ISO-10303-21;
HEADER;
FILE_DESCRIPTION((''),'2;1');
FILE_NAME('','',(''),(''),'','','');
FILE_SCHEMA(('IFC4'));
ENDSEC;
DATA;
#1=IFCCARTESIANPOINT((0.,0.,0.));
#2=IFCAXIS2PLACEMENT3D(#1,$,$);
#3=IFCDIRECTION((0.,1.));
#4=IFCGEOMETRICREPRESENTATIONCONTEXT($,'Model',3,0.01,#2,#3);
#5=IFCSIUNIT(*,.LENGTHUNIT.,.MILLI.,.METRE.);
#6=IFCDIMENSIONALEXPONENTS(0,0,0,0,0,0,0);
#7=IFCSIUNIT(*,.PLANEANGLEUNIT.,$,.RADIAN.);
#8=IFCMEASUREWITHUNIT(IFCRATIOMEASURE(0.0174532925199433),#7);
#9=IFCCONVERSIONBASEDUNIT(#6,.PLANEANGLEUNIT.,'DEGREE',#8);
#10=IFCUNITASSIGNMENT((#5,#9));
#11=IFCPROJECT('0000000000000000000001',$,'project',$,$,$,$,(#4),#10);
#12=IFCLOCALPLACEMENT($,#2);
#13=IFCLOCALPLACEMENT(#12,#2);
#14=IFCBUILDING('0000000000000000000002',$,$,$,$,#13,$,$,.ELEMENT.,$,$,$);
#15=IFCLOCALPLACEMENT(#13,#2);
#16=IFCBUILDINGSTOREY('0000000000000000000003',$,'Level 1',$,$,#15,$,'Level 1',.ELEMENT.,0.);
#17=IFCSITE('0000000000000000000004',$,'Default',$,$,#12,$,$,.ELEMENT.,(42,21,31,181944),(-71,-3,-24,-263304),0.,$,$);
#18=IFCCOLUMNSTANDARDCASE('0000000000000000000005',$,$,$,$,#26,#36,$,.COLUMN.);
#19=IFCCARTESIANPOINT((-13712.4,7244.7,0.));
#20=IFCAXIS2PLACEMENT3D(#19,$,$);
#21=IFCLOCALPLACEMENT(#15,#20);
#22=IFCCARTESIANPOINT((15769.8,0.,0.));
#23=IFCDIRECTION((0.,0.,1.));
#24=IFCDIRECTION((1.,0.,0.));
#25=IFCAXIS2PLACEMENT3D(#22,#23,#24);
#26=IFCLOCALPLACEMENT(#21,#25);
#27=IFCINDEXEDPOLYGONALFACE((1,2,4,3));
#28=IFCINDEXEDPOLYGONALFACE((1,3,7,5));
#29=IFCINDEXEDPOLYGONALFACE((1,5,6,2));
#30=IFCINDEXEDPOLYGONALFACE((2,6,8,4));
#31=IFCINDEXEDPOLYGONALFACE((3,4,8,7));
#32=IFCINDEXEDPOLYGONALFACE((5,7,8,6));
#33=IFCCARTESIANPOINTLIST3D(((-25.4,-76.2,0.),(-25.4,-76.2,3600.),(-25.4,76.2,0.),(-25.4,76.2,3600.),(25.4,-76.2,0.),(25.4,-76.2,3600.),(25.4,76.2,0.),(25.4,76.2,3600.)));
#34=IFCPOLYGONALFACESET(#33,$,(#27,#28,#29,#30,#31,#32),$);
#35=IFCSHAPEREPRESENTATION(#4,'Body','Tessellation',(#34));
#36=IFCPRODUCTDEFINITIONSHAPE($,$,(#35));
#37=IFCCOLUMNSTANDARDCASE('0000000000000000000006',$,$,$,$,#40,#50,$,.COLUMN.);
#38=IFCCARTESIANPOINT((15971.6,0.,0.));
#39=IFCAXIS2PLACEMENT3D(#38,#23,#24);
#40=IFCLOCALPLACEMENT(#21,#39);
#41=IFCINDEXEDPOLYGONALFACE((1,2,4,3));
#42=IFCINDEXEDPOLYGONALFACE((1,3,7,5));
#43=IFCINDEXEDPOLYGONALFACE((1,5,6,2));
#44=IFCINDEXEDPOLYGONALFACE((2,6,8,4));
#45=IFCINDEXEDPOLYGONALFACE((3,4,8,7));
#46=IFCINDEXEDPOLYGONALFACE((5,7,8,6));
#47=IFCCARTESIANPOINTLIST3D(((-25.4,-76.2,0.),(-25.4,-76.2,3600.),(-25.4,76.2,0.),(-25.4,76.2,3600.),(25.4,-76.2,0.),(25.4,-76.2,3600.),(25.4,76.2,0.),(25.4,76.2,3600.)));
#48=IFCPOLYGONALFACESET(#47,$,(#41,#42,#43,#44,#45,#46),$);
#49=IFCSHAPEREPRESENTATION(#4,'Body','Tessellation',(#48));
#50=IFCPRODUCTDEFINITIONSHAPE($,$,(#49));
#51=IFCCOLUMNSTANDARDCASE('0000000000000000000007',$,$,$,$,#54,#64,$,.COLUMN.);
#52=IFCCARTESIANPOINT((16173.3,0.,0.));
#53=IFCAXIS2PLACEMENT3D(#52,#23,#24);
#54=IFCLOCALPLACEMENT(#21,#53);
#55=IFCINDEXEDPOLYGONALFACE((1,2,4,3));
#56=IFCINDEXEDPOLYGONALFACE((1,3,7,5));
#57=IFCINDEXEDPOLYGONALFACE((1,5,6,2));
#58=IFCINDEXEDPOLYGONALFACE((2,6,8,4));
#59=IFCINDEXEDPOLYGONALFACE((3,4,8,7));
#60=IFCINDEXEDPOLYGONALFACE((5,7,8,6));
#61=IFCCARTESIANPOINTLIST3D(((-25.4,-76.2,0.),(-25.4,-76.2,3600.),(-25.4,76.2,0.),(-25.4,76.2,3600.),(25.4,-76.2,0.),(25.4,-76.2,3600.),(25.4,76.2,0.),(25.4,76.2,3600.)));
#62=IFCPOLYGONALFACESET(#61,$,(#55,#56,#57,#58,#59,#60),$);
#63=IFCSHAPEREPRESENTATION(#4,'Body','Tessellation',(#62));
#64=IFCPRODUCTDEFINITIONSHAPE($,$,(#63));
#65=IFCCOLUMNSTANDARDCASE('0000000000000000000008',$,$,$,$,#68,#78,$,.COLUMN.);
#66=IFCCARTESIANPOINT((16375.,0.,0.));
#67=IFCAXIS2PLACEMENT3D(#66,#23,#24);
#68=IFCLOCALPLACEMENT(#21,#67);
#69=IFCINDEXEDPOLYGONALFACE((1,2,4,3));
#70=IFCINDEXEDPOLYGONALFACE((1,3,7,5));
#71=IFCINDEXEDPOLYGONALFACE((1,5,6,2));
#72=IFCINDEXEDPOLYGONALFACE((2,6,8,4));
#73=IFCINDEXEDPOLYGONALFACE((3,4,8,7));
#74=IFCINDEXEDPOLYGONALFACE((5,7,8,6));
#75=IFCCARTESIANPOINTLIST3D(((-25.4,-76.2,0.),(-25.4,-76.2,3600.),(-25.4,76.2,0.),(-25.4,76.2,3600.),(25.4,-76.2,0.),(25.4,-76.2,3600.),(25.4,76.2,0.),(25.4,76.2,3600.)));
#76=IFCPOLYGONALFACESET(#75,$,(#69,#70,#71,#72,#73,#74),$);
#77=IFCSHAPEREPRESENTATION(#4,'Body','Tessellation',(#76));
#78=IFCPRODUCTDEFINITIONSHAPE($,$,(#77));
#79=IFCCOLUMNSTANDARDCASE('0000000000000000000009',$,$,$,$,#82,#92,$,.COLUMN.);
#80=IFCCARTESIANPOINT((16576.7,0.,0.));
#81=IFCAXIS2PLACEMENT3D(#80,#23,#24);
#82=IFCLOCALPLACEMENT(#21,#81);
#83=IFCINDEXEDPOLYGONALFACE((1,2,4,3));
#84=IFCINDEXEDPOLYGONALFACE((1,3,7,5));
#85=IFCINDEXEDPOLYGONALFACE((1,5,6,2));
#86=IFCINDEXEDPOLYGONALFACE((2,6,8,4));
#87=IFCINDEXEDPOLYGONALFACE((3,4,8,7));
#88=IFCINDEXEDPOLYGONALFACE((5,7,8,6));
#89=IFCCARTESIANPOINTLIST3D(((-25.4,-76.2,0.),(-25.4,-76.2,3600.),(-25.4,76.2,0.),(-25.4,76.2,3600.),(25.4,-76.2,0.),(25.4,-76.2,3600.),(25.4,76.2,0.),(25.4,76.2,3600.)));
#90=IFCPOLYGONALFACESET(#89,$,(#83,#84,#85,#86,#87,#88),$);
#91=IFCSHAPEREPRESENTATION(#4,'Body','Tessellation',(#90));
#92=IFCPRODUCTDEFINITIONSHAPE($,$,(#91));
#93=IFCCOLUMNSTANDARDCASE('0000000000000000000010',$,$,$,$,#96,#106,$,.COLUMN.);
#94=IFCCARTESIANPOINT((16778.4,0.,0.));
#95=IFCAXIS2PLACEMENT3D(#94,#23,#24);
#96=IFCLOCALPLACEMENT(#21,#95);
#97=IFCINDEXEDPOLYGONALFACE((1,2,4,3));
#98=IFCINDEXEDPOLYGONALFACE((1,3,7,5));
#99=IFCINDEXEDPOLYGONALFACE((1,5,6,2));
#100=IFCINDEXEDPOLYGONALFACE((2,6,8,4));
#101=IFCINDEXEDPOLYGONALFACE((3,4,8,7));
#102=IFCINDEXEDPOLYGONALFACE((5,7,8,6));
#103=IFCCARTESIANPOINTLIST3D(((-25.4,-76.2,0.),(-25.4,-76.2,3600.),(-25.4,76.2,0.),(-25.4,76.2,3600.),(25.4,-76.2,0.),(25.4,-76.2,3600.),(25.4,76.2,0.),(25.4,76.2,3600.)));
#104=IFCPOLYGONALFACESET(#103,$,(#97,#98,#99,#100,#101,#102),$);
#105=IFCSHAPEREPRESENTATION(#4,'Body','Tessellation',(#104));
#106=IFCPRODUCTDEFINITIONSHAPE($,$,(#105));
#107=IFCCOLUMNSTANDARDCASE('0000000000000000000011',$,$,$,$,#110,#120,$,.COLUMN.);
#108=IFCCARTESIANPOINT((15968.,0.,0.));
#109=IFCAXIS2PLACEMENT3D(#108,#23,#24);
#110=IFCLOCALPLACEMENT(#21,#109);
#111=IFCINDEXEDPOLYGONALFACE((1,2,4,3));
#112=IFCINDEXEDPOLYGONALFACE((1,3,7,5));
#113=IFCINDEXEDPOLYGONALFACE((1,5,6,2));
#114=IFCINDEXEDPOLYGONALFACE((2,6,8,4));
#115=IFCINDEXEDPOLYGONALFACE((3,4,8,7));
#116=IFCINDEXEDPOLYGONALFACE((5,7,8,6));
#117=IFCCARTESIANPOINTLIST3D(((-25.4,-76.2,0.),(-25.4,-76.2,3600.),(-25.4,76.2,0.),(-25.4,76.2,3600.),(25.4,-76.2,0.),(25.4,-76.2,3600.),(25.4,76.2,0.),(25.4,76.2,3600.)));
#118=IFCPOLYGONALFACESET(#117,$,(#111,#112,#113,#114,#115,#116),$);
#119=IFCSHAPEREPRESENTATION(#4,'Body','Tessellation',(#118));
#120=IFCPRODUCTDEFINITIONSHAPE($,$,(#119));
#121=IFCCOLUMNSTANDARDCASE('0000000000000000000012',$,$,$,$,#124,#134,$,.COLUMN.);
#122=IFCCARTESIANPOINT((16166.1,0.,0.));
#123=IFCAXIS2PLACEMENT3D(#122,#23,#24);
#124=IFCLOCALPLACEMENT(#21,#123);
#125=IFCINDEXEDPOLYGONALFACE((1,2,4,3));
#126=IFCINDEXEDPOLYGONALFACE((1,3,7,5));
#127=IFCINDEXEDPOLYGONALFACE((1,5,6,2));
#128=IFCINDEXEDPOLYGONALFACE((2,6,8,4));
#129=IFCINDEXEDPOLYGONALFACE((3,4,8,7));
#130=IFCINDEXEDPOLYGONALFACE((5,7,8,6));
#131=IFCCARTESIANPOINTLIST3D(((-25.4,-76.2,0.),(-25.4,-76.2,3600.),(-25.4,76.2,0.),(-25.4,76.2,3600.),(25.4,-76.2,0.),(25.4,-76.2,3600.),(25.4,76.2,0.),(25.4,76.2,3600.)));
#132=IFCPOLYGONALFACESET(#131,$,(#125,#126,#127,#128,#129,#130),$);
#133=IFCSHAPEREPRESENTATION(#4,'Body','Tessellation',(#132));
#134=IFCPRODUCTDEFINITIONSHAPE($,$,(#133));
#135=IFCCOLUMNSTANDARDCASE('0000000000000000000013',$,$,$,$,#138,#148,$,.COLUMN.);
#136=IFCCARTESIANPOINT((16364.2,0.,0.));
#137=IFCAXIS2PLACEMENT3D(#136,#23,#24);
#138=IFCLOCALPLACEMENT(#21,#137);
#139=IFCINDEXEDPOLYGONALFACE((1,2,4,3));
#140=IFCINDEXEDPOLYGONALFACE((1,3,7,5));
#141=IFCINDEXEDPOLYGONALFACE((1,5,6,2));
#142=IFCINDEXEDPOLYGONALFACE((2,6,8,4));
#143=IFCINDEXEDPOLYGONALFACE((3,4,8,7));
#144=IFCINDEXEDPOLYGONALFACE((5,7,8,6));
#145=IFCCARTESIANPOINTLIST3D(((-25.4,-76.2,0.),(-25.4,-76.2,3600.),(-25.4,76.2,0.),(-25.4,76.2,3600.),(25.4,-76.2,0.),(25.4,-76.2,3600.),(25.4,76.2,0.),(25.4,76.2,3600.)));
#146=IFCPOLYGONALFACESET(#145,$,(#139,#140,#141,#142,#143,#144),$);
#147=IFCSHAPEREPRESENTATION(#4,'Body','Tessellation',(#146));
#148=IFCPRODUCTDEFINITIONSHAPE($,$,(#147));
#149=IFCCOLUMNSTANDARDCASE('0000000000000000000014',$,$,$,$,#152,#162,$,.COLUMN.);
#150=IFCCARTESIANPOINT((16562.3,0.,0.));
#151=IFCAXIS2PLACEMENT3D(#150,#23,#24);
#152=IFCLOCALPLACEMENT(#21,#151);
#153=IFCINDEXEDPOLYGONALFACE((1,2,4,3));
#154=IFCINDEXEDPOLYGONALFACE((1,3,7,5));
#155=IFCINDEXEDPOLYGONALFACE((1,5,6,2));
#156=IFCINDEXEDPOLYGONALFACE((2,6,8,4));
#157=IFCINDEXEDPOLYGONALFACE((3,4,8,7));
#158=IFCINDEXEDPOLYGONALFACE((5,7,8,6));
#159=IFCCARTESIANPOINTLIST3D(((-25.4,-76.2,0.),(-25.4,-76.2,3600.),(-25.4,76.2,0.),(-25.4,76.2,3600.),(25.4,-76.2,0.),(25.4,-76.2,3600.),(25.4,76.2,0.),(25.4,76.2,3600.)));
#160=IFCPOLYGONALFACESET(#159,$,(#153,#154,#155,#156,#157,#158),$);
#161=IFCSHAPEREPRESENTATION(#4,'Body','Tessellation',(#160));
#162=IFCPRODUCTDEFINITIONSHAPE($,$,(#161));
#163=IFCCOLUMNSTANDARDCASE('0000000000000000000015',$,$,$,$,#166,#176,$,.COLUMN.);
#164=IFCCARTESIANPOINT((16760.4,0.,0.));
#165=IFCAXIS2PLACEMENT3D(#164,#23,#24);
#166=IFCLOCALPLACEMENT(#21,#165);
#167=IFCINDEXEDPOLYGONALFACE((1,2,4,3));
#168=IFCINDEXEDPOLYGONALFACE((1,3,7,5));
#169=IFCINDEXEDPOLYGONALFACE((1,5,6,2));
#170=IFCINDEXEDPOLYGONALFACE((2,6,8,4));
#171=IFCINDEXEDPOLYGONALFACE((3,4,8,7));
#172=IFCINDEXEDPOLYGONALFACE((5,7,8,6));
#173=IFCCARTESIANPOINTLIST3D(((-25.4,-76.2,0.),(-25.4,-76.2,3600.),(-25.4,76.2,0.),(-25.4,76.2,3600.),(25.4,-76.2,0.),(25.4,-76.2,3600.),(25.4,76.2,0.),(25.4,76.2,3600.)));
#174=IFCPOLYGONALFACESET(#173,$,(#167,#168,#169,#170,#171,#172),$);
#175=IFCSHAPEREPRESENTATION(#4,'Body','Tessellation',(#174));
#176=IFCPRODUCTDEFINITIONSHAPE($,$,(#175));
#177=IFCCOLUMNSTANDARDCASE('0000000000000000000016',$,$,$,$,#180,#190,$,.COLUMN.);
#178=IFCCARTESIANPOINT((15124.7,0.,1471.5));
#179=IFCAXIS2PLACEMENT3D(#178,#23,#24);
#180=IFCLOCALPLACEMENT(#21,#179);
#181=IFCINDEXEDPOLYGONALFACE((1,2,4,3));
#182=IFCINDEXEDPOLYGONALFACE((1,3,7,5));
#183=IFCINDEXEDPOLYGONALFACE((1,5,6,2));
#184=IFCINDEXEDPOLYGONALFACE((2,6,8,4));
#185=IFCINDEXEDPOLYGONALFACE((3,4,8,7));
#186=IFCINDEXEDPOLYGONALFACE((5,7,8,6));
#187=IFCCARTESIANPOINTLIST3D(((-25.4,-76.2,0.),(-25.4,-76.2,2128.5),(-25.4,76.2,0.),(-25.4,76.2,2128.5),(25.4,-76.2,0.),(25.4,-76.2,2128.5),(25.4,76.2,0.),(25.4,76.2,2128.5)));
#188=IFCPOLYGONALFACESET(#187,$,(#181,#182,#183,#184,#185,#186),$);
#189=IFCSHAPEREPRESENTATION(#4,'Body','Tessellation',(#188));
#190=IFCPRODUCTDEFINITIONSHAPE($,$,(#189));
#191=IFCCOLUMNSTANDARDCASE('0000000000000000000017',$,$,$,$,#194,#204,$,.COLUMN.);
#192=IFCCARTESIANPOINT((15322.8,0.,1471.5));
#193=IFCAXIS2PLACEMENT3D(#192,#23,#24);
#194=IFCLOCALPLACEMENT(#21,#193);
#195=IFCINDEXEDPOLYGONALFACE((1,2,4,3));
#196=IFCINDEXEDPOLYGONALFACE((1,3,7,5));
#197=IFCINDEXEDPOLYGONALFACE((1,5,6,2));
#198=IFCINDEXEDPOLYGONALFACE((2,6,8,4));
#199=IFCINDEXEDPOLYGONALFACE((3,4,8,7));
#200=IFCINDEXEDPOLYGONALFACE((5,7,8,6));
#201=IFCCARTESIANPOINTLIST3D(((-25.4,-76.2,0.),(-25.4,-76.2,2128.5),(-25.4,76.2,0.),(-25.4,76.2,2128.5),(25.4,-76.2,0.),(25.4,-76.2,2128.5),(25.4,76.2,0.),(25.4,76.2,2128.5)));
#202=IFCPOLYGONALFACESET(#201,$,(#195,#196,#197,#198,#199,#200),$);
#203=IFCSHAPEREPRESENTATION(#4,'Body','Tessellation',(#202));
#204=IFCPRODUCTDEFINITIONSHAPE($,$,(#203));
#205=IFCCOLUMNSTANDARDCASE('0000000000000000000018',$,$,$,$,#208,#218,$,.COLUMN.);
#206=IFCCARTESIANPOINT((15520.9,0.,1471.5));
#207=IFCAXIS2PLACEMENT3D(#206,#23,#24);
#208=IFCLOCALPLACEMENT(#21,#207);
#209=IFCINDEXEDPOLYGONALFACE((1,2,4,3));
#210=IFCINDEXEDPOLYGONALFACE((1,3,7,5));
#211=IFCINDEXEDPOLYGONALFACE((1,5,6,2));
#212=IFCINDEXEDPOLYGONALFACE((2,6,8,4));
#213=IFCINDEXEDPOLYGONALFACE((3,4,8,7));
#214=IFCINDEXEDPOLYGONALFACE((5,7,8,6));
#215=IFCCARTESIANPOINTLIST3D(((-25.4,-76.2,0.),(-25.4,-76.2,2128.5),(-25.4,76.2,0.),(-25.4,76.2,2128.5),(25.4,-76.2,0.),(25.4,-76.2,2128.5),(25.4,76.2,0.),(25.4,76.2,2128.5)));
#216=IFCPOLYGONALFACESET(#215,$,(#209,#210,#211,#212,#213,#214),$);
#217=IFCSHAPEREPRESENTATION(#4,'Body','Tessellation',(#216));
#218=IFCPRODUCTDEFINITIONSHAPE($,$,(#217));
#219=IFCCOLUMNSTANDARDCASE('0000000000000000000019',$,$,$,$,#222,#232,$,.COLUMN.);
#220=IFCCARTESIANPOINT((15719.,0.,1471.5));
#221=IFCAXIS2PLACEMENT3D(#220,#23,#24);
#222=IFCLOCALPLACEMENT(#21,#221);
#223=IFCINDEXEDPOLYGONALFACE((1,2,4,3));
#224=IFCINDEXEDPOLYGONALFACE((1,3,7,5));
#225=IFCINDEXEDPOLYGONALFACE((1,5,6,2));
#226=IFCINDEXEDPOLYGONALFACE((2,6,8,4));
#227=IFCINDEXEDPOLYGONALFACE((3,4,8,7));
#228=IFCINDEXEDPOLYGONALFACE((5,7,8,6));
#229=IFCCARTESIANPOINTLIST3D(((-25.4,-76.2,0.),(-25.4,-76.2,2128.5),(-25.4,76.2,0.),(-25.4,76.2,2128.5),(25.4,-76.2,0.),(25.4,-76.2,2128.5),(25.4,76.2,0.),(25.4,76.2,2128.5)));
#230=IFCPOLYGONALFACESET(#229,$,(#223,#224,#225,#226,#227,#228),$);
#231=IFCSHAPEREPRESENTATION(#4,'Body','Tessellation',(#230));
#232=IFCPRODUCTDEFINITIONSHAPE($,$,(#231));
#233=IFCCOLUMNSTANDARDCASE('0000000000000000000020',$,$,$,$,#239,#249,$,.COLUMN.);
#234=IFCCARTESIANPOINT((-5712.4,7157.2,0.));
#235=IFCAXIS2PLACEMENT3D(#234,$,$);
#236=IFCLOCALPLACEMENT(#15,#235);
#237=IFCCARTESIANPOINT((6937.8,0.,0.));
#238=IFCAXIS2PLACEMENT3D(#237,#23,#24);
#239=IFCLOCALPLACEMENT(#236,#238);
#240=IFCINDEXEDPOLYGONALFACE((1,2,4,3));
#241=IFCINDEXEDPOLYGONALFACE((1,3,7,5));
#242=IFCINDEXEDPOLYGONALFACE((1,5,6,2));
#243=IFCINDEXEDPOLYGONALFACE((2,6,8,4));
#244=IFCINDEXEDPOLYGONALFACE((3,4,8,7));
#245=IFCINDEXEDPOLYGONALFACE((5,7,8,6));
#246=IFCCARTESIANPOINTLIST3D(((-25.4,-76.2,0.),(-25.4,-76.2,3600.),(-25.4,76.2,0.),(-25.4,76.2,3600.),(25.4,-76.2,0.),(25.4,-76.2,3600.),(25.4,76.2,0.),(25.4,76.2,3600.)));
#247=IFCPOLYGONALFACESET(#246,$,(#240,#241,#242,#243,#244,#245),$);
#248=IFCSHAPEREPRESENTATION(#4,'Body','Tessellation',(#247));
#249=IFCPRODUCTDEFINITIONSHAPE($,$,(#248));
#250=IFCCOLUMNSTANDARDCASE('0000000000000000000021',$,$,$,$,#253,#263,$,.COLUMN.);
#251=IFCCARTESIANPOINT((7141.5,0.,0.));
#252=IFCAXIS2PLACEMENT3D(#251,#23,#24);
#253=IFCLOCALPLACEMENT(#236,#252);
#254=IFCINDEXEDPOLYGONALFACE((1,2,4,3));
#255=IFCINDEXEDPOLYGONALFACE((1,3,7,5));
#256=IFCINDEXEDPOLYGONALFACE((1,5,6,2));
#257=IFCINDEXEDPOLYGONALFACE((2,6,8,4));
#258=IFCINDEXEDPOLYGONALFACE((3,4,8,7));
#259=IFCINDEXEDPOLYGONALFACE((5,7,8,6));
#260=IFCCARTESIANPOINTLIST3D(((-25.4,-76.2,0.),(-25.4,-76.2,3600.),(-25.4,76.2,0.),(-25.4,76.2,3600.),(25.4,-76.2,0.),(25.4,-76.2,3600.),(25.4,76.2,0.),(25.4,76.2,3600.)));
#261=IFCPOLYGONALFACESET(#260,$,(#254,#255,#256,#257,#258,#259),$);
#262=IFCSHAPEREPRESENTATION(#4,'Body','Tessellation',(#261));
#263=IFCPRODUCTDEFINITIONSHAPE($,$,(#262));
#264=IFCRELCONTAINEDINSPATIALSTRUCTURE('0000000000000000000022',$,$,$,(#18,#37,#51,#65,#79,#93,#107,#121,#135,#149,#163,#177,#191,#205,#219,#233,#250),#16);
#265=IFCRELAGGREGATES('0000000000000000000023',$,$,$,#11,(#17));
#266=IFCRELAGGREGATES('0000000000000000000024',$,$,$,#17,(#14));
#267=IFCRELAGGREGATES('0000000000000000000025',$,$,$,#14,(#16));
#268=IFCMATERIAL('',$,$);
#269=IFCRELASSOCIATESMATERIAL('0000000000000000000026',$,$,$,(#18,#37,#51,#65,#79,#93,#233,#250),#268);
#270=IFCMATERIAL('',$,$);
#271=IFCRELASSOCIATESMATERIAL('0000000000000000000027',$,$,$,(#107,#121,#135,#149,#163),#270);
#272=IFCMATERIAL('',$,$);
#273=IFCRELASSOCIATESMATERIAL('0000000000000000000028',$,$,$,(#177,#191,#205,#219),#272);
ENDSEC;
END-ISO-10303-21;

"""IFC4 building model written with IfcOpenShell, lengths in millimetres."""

from ifc_helpers import new_model, entity, si_unit, converted_unit, direction, frame, origin, place, context, project, spatial, rectangle, extrude, material, element, save


model = new_model("IFC4")

# Units and contexts
model_context = context("Model", 3, precision=0.01, world=origin(), true_north=direction((0.0, 1.0)))
ifc_project = project(units=[si_unit("LENGTHUNIT", "METRE", prefix="MILLI"), converted_unit("PLANEANGLEUNIT", "DEGREE", entity("IfcRatioMeasure", 0.0174532925199433), si_unit("PLANEANGLEUNIT", "RADIAN"), dimensions=[0, 0, 0, 0, 0, 0, 0])], contexts=[model_context])

# Site, building, storey
site_placement = place(None, origin())
site = spatial("IfcSite", under=ifc_project, at=site_placement, Name="Default", CompositionType="ELEMENT", RefLatitude=(42, 21, 31, 181944), RefLongitude=(-71, -3, -24, -263304), RefElevation=0.0)
building_placement = place(site_placement, origin())
building = spatial("IfcBuilding", under=site, at=building_placement, CompositionType="ELEMENT")
storey_placement = place(building_placement, origin())
storey = spatial("IfcBuildingStorey", under=building, at=storey_placement, Name="Level 1", LongName="Level 1", CompositionType="ELEMENT", Elevation=0.0)

# Columns
ifc_material_1 = material(Name="")
placement_1 = place(storey_placement, frame((-13712.4, 7244.7, 0.0)))
for number, where, z_axis, x_axis in (
    (1, (15769.8, 0.0, 0.0), (0.0, 0.0, 1.0), (1.0, 0.0, 0.0)),
    (2, (15971.6, 0.0, 0.0), (0.0, 0.0, 1.0), (1.0, 0.0, 0.0)),
    (3, (16173.3, 0.0, 0.0), (0.0, 0.0, 1.0), (1.0, 0.0, 0.0)),
    (4, (16375.0, 0.0, 0.0), (0.0, 0.0, 1.0), (1.0, 0.0, 0.0)),
    (5, (16576.7, 0.0, 0.0), (0.0, 0.0, 1.0), (1.0, 0.0, 0.0)),
    (6, (16778.4, 0.0, 0.0), (0.0, 0.0, 1.0), (1.0, 0.0, 0.0)),
):
    element("IfcColumnStandardCase", number, at=place(placement_1, frame(where, z_axis=z_axis, x_axis=x_axis)), inside=storey, material=ifc_material_1, PredefinedType="COLUMN", context=model_context, shape_type="SweptSolid", body=[
        extrude(rectangle(XDim=50.8, YDim=152.4), origin(), (0.0, 0.0, 1.0), 3600.0),
    ])
ifc_material_2 = material(Name="")
for number, where, z_axis, x_axis in (
    (7, (15968.0, 0.0, 0.0), (0.0, 0.0, 1.0), (1.0, 0.0, 0.0)),
    (8, (16166.1, 0.0, 0.0), (0.0, 0.0, 1.0), (1.0, 0.0, 0.0)),
    (9, (16364.2, 0.0, 0.0), (0.0, 0.0, 1.0), (1.0, 0.0, 0.0)),
    (10, (16562.3, 0.0, 0.0), (0.0, 0.0, 1.0), (1.0, 0.0, 0.0)),
    (11, (16760.4, 0.0, 0.0), (0.0, 0.0, 1.0), (1.0, 0.0, 0.0)),
):
    element("IfcColumnStandardCase", number, at=place(placement_1, frame(where, z_axis=z_axis, x_axis=x_axis)), inside=storey, material=ifc_material_2, PredefinedType="COLUMN", context=model_context, shape_type="SweptSolid", body=[
        extrude(rectangle(XDim=50.8, YDim=152.4), origin(), (0.0, 0.0, 1.0), 3600.0),
    ])
ifc_material_3 = material(Name="")
for number, where, z_axis, x_axis in (
    (12, (15124.7, 0.0, 1471.5), (0.0, 0.0, 1.0), (1.0, 0.0, 0.0)),
    (13, (15322.8, 0.0, 1471.5), (0.0, 0.0, 1.0), (1.0, 0.0, 0.0)),
    (14, (15520.9, 0.0, 1471.5), (0.0, 0.0, 1.0), (1.0, 0.0, 0.0)),
    (15, (15719.0, 0.0, 1471.5), (0.0, 0.0, 1.0), (1.0, 0.0, 0.0)),
):
    element("IfcColumnStandardCase", number, at=place(placement_1, frame(where, z_axis=z_axis, x_axis=x_axis)), inside=storey, material=ifc_material_3, PredefinedType="COLUMN", context=model_context, shape_type="SweptSolid", body=[
        extrude(rectangle(XDim=50.8, YDim=152.4), origin(), (0.0, 0.0, 1.0), 2128.5),
    ])
placement_2 = place(storey_placement, frame((-5712.4, 7157.2, 0.0)))
for number, where, z_axis, x_axis in (
    (16, (6937.8, 0.0, 0.0), (0.0, 0.0, 1.0), (1.0, 0.0, 0.0)),
    (17, (7141.5, 0.0, 0.0), (0.0, 0.0, 1.0), (1.0, 0.0, 0.0)),
):
    element("IfcColumnStandardCase", number, at=place(placement_2, frame(where, z_axis=z_axis, x_axis=x_axis)), inside=storey, material=ifc_material_1, PredefinedType="COLUMN", context=model_context, shape_type="SweptSolid", body=[
        extrude(rectangle(XDim=50.8, YDim=152.4), origin(), (0.0, 0.0, 1.0), 3600.0),
    ])

save(model, "model.ifc")
